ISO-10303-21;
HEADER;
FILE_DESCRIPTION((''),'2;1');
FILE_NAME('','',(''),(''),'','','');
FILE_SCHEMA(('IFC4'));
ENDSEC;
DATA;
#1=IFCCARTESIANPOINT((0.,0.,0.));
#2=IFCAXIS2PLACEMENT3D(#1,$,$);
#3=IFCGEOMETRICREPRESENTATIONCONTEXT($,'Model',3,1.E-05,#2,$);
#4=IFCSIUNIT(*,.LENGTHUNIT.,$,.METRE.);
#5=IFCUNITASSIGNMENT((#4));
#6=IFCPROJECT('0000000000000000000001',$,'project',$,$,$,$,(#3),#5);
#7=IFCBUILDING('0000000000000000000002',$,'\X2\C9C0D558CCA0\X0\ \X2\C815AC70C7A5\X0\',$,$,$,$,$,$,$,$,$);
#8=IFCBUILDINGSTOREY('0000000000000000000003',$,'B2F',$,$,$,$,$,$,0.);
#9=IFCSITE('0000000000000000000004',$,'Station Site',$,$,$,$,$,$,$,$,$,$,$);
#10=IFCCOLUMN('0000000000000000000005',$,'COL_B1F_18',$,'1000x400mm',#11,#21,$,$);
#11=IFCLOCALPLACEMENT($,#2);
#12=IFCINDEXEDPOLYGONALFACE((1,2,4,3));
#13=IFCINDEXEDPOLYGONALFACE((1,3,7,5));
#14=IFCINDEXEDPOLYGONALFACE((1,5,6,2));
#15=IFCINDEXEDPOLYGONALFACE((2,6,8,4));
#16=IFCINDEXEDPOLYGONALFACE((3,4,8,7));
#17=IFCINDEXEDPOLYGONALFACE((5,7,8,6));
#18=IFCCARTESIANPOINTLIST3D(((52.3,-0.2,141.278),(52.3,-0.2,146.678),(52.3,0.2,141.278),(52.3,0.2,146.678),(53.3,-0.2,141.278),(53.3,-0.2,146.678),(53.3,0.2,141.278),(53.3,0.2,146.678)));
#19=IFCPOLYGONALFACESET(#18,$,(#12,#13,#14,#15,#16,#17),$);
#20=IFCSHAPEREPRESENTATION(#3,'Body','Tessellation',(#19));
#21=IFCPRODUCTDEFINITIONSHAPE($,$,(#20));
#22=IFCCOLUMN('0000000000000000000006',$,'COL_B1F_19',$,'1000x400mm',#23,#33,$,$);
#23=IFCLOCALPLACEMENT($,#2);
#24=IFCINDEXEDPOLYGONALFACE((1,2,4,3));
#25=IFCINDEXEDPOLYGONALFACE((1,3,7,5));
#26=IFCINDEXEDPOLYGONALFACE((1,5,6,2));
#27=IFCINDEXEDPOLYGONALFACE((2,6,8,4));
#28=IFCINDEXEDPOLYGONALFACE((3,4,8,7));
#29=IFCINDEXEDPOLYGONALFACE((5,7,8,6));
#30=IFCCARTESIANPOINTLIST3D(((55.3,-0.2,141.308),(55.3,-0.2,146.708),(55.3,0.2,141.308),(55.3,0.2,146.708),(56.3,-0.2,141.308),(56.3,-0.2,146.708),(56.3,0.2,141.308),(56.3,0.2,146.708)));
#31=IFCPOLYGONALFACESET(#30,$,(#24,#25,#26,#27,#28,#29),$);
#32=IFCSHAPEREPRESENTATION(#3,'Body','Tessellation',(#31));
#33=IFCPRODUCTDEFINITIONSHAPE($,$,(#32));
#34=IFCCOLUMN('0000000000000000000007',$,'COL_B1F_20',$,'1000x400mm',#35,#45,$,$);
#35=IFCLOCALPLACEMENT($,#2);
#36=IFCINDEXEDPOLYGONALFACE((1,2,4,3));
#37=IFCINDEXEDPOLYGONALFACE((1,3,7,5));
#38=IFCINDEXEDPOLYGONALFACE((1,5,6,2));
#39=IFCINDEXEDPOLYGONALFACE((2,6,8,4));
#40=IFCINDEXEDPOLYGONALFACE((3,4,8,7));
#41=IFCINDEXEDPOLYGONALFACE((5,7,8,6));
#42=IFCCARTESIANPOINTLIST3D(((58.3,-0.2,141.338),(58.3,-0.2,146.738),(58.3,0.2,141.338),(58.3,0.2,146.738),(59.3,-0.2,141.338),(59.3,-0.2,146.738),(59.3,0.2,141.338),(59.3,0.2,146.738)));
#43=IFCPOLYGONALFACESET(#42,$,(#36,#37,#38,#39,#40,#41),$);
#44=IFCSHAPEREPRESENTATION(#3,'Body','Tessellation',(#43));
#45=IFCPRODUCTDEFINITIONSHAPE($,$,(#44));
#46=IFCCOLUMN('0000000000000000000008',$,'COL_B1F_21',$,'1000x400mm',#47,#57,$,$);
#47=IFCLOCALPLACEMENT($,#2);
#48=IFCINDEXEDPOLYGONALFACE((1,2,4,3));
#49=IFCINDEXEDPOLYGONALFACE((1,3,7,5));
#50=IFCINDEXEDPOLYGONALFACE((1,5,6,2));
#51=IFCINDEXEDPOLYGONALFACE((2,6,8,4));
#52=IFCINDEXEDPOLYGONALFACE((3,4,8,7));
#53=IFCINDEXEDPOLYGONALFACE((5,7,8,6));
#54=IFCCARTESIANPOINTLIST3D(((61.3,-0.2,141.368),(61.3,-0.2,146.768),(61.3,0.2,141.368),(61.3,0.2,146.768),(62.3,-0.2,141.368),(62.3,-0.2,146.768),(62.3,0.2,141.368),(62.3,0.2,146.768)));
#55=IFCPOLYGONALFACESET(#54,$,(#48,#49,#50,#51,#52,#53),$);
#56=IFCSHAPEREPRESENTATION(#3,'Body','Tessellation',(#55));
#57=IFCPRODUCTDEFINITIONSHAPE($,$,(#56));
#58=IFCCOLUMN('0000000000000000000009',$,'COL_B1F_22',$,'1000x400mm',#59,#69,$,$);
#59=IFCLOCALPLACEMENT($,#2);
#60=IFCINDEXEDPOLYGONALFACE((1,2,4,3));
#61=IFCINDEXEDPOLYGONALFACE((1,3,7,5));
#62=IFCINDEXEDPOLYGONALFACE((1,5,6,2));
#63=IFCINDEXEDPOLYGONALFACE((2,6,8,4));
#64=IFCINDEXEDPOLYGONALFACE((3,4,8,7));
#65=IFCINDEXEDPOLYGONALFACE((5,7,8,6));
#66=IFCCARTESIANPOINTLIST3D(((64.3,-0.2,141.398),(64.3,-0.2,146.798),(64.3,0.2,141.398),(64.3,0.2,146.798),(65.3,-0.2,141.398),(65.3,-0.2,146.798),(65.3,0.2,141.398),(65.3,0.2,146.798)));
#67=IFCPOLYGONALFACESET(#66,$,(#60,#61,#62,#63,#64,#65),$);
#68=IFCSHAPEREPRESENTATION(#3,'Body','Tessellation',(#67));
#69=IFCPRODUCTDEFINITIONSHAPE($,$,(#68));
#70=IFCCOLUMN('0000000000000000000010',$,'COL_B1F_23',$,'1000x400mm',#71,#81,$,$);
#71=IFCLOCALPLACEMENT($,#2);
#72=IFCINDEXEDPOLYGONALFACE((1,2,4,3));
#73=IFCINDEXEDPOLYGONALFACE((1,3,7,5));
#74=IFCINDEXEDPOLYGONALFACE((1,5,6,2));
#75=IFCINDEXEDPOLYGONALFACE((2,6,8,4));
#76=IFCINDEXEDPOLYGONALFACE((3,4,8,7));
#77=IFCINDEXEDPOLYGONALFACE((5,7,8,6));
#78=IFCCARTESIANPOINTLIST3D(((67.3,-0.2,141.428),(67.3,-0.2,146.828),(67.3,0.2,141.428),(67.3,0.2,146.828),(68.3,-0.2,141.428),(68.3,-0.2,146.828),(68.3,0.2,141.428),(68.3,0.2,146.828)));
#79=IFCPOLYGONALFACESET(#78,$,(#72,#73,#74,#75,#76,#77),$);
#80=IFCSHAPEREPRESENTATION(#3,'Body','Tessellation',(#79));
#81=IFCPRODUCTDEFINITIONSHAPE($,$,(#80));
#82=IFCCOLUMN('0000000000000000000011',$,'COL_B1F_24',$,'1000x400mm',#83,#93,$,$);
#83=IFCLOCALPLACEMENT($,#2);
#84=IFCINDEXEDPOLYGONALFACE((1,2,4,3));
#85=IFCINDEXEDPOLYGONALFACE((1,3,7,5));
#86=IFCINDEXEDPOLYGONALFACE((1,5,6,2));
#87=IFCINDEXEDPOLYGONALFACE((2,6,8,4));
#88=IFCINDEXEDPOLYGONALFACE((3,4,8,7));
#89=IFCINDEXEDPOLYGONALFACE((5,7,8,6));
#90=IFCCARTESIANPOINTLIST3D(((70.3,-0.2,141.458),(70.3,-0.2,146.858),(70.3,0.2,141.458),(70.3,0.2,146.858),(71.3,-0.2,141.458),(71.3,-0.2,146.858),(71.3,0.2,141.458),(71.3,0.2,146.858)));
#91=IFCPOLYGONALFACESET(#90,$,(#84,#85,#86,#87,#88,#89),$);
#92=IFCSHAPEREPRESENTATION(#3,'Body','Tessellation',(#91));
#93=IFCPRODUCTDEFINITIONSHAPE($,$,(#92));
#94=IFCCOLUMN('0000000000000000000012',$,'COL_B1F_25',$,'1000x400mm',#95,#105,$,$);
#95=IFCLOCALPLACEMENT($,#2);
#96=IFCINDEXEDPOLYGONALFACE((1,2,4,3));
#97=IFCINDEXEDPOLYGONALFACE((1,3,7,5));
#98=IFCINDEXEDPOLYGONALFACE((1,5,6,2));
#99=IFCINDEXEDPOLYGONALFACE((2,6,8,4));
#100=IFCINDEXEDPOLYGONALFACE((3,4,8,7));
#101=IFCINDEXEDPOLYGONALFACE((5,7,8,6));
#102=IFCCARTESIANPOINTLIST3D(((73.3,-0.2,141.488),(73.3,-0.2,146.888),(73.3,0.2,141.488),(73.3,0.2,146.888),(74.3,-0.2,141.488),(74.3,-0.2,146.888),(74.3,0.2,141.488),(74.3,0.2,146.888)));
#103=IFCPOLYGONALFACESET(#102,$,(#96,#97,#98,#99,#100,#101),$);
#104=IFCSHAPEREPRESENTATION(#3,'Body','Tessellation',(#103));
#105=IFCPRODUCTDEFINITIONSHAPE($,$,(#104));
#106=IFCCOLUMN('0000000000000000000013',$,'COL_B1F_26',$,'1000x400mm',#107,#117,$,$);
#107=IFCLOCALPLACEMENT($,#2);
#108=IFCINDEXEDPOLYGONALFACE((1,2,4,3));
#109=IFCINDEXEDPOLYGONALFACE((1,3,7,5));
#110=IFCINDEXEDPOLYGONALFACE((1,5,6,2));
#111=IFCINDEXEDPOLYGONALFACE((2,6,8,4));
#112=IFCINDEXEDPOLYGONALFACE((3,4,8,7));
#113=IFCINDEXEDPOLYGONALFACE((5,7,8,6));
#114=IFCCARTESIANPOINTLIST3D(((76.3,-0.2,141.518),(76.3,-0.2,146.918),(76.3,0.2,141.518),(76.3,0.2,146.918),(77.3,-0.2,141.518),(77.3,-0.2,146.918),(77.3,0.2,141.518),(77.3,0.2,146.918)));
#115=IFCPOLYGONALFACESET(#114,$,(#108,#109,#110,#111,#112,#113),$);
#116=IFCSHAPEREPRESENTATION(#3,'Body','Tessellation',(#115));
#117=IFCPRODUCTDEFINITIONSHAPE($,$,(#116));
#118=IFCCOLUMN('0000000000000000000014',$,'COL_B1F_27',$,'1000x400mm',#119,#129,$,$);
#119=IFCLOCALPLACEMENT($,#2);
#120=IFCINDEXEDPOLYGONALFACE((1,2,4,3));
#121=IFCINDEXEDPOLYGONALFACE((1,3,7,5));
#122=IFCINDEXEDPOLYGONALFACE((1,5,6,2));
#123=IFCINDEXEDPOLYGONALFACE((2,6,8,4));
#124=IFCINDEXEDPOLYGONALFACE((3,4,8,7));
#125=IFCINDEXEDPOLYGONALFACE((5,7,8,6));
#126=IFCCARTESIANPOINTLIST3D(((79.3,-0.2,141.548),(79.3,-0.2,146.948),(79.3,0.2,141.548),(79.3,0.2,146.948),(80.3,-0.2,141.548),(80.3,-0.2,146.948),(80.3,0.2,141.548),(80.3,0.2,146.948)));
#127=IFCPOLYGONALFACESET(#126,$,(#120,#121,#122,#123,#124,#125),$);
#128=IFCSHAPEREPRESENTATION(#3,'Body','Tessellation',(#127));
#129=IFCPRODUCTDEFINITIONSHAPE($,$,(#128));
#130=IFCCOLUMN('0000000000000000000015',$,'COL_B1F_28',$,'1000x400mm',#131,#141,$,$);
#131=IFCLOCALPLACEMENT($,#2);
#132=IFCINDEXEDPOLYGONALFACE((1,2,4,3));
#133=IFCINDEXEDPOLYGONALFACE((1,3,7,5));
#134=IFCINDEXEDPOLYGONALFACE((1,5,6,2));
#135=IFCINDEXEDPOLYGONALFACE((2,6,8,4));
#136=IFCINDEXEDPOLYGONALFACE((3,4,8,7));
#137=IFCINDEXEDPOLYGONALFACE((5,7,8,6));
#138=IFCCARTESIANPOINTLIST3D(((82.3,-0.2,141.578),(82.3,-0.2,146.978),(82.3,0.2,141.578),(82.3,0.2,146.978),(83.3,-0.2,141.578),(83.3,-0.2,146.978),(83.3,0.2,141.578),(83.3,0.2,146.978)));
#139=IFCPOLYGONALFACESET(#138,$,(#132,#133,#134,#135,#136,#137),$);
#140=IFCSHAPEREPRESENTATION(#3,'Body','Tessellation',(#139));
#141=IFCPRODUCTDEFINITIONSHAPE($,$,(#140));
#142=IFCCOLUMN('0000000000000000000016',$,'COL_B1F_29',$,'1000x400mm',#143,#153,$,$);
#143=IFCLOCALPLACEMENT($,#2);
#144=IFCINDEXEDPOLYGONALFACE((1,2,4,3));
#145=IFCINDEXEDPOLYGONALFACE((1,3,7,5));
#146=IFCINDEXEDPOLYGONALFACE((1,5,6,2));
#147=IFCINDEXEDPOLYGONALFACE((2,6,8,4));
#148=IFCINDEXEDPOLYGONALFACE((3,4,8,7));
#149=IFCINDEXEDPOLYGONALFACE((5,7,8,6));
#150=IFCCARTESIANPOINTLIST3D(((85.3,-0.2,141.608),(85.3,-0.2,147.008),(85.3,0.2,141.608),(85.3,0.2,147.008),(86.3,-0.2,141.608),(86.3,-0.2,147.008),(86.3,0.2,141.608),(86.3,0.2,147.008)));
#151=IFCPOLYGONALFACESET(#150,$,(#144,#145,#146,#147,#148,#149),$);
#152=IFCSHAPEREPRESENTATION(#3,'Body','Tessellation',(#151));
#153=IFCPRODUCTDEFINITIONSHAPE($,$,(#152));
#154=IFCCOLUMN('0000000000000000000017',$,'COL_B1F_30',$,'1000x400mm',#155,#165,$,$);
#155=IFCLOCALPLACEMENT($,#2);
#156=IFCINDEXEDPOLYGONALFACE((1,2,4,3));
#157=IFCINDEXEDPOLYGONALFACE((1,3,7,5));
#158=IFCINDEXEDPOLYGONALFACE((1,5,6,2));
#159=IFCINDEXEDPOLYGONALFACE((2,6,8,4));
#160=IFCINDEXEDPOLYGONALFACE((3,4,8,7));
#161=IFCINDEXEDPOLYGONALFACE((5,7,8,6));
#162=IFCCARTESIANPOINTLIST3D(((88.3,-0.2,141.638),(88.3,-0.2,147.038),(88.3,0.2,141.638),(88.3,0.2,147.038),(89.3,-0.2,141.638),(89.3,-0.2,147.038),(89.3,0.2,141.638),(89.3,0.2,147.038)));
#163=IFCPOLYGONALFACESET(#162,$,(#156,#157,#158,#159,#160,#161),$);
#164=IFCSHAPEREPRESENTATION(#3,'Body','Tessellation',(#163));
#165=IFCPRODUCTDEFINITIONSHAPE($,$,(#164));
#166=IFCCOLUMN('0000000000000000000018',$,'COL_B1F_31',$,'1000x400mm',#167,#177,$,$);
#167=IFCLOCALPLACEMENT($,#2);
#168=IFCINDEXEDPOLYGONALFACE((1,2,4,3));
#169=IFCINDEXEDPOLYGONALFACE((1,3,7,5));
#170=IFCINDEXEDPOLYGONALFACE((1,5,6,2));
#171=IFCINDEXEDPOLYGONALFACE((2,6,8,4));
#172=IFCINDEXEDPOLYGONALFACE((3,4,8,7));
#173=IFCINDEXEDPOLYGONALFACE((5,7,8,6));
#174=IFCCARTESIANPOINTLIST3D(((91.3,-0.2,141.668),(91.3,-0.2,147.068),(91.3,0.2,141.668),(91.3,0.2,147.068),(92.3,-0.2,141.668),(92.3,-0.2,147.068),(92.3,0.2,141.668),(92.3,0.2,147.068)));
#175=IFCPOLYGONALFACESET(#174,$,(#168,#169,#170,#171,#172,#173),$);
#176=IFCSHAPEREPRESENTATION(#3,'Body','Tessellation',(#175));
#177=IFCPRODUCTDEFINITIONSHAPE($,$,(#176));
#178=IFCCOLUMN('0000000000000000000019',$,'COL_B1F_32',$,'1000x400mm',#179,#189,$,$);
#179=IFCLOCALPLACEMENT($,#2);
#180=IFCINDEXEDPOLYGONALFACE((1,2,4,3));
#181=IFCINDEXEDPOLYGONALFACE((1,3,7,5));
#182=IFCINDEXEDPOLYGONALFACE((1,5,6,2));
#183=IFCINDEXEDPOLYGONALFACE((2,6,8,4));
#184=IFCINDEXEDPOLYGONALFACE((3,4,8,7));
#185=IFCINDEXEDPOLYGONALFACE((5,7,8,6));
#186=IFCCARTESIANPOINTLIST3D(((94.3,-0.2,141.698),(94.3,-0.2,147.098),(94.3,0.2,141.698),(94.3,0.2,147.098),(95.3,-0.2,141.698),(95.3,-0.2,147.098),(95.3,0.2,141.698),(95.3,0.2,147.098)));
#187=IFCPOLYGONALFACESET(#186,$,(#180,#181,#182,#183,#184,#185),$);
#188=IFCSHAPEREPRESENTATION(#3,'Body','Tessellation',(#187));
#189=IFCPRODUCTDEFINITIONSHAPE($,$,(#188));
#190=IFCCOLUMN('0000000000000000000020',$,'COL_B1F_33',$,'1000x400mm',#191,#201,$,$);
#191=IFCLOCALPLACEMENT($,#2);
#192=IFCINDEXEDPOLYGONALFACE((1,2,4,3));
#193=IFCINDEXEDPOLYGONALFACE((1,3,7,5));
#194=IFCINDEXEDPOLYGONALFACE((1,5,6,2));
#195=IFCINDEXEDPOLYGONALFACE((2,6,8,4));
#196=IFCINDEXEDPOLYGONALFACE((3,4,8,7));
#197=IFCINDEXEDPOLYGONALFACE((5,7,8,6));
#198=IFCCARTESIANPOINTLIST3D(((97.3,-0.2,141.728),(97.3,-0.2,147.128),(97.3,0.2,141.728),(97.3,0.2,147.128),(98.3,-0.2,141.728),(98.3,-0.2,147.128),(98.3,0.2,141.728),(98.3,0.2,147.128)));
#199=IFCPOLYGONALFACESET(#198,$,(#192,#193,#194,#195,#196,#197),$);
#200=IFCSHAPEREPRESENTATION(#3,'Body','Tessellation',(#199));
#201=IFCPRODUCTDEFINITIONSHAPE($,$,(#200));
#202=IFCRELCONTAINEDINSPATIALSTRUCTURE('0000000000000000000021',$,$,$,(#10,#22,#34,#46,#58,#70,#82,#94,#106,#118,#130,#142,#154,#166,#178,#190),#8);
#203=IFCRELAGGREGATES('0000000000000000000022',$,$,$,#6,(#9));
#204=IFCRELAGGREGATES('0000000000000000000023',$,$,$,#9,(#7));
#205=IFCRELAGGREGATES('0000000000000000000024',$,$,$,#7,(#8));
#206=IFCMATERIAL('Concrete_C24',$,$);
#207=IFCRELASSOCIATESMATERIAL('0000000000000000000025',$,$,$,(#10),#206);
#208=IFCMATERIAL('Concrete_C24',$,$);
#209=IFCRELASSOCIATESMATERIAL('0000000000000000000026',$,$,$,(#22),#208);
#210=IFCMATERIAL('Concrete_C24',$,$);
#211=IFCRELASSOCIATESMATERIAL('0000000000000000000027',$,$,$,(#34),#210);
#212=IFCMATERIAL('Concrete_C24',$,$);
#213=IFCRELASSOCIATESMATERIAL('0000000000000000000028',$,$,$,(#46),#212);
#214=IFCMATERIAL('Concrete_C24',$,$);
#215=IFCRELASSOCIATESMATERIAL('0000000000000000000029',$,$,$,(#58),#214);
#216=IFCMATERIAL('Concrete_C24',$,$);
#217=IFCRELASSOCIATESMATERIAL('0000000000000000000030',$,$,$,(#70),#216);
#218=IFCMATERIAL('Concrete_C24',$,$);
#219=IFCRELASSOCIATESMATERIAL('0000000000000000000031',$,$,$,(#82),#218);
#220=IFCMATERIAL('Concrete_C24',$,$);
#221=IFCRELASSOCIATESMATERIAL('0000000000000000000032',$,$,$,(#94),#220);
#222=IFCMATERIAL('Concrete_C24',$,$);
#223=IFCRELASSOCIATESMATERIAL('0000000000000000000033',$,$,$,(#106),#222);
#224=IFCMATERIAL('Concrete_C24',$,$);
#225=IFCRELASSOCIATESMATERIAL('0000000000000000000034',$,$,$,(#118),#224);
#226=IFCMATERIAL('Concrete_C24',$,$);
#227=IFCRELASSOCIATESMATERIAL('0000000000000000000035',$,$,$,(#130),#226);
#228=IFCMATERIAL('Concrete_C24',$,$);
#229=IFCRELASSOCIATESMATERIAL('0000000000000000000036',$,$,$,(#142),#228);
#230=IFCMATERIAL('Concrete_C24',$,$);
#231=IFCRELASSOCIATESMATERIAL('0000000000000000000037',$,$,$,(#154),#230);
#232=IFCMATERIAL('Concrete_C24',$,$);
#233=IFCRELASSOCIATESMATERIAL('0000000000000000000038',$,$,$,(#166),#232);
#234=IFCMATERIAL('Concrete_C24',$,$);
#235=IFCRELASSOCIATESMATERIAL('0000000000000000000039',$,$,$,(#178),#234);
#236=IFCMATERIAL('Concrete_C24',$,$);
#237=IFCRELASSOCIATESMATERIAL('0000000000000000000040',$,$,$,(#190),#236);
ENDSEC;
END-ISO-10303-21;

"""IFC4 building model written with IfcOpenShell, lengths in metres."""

from ifc_helpers import new_model, si_unit, frame, origin, place, context, project, spatial, rectangle, extrude, material, element, save


model = new_model("IFC4")

# Units and contexts
model_context = context("Model", 3, precision=1e-05, world=origin())
ifc_project = project(units=[si_unit("LENGTHUNIT", "METRE")], contexts=[model_context])

# Site, building, storey
site = spatial("IfcSite", under=ifc_project, Name="Station Site")
building = spatial("IfcBuilding", under=site, Name="지하철 정거장")
storey = spatial("IfcBuildingStorey", under=building, Name="B2F", Elevation=0.0)

# Columns
ifc_material_1 = material(Name="Concrete_C24")
column_1_placement = place(None, frame((52.8, 0.0, 141.278)))
element("IfcColumn", 1, at=column_1_placement, inside=storey, material=ifc_material_1, Name="COL_B1F_18", ObjectType="1000x400mm", context=model_context, shape_type="SweptSolid", body=[
    extrude(rectangle(XDim=1.0, YDim=0.4), origin(), (0.0, 0.0, 1.0), 5.4),
])
ifc_material_2 = material(Name="Concrete_C24")
column_2_placement = place(None, frame((55.8, 0.0, 141.308)))
element("IfcColumn", 2, at=column_2_placement, inside=storey, material=ifc_material_2, Name="COL_B1F_19", ObjectType="1000x400mm", context=model_context, shape_type="SweptSolid", body=[
    extrude(rectangle(XDim=1.0, YDim=0.4), origin(), (0.0, 0.0, 1.0), 5.4),
])
ifc_material_3 = material(Name="Concrete_C24")
column_3_placement = place(None, frame((58.8, 0.0, 141.338)))
element("IfcColumn", 3, at=column_3_placement, inside=storey, material=ifc_material_3, Name="COL_B1F_20", ObjectType="1000x400mm", context=model_context, shape_type="SweptSolid", body=[
    extrude(rectangle(XDim=1.0, YDim=0.4), origin(), (0.0, 0.0, 1.0), 5.4),
])
ifc_material_4 = material(Name="Concrete_C24")
column_4_placement = place(None, frame((61.8, 0.0, 141.368)))
element("IfcColumn", 4, at=column_4_placement, inside=storey, material=ifc_material_4, Name="COL_B1F_21", ObjectType="1000x400mm", context=model_context, shape_type="SweptSolid", body=[
    extrude(rectangle(XDim=1.0, YDim=0.4), origin(), (0.0, 0.0, 1.0), 5.4),
])
ifc_material_5 = material(Name="Concrete_C24")
column_5_placement = place(None, frame((64.8, 0.0, 141.398)))
element("IfcColumn", 5, at=column_5_placement, inside=storey, material=ifc_material_5, Name="COL_B1F_22", ObjectType="1000x400mm", context=model_context, shape_type="SweptSolid", body=[
    extrude(rectangle(XDim=1.0, YDim=0.4), origin(), (0.0, 0.0, 1.0), 5.4),
])
ifc_material_6 = material(Name="Concrete_C24")
column_6_placement = place(None, frame((67.8, 0.0, 141.428)))
element("IfcColumn", 6, at=column_6_placement, inside=storey, material=ifc_material_6, Name="COL_B1F_23", ObjectType="1000x400mm", context=model_context, shape_type="SweptSolid", body=[
    extrude(rectangle(XDim=1.0, YDim=0.4), origin(), (0.0, 0.0, 1.0), 5.4),
])
ifc_material_7 = material(Name="Concrete_C24")
column_7_placement = place(None, frame((70.8, 0.0, 141.458)))
element("IfcColumn", 7, at=column_7_placement, inside=storey, material=ifc_material_7, Name="COL_B1F_24", ObjectType="1000x400mm", context=model_context, shape_type="SweptSolid", body=[
    extrude(rectangle(XDim=1.0, YDim=0.4), origin(), (0.0, 0.0, 1.0), 5.4),
])
ifc_material_8 = material(Name="Concrete_C24")
column_8_placement = place(None, frame((73.8, 0.0, 141.488)))
element("IfcColumn", 8, at=column_8_placement, inside=storey, material=ifc_material_8, Name="COL_B1F_25", ObjectType="1000x400mm", context=model_context, shape_type="SweptSolid", body=[
    extrude(rectangle(XDim=1.0, YDim=0.4), origin(), (0.0, 0.0, 1.0), 5.4),
])
ifc_material_9 = material(Name="Concrete_C24")
column_9_placement = place(None, frame((76.8, 0.0, 141.518)))
element("IfcColumn", 9, at=column_9_placement, inside=storey, material=ifc_material_9, Name="COL_B1F_26", ObjectType="1000x400mm", context=model_context, shape_type="SweptSolid", body=[
    extrude(rectangle(XDim=1.0, YDim=0.4), origin(), (0.0, 0.0, 1.0), 5.4),
])
ifc_material_10 = material(Name="Concrete_C24")
column_10_placement = place(None, frame((79.8, 0.0, 141.548)))
element("IfcColumn", 10, at=column_10_placement, inside=storey, material=ifc_material_10, Name="COL_B1F_27", ObjectType="1000x400mm", context=model_context, shape_type="SweptSolid", body=[
    extrude(rectangle(XDim=1.0, YDim=0.4), origin(), (0.0, 0.0, 1.0), 5.4),
])
ifc_material_11 = material(Name="Concrete_C24")
column_11_placement = place(None, frame((82.8, 0.0, 141.578)))
element("IfcColumn", 11, at=column_11_placement, inside=storey, material=ifc_material_11, Name="COL_B1F_28", ObjectType="1000x400mm", context=model_context, shape_type="SweptSolid", body=[
    extrude(rectangle(XDim=1.0, YDim=0.4), origin(), (0.0, 0.0, 1.0), 5.4),
])
ifc_material_12 = material(Name="Concrete_C24")
column_12_placement = place(None, frame((85.8, 0.0, 141.608)))
element("IfcColumn", 12, at=column_12_placement, inside=storey, material=ifc_material_12, Name="COL_B1F_29", ObjectType="1000x400mm", context=model_context, shape_type="SweptSolid", body=[
    extrude(rectangle(XDim=1.0, YDim=0.4), origin(), (0.0, 0.0, 1.0), 5.4),
])
ifc_material_13 = material(Name="Concrete_C24")
column_13_placement = place(None, frame((88.8, 0.0, 141.638)))
element("IfcColumn", 13, at=column_13_placement, inside=storey, material=ifc_material_13, Name="COL_B1F_30", ObjectType="1000x400mm", context=model_context, shape_type="SweptSolid", body=[
    extrude(rectangle(XDim=1.0, YDim=0.4), origin(), (0.0, 0.0, 1.0), 5.4),
])
ifc_material_14 = material(Name="Concrete_C24")
column_14_placement = place(None, frame((91.8, 0.0, 141.668)))
element("IfcColumn", 14, at=column_14_placement, inside=storey, material=ifc_material_14, Name="COL_B1F_31", ObjectType="1000x400mm", context=model_context, shape_type="SweptSolid", body=[
    extrude(rectangle(XDim=1.0, YDim=0.4), origin(), (0.0, 0.0, 1.0), 5.4),
])
ifc_material_15 = material(Name="Concrete_C24")
column_15_placement = place(None, frame((94.8, 0.0, 141.698)))
element("IfcColumn", 15, at=column_15_placement, inside=storey, material=ifc_material_15, Name="COL_B1F_32", ObjectType="1000x400mm", context=model_context, shape_type="SweptSolid", body=[
    extrude(rectangle(XDim=1.0, YDim=0.4), origin(), (0.0, 0.0, 1.0), 5.4),
])
ifc_material_16 = material(Name="Concrete_C24")
column_16_placement = place(None, frame((97.8, 0.0, 141.728)))
element("IfcColumn", 16, at=column_16_placement, inside=storey, material=ifc_material_16, Name="COL_B1F_33", ObjectType="1000x400mm", context=model_context, shape_type="SweptSolid", body=[
    extrude(rectangle(XDim=1.0, YDim=0.4), origin(), (0.0, 0.0, 1.0), 5.4),
])

save(model, "model.ifc")
